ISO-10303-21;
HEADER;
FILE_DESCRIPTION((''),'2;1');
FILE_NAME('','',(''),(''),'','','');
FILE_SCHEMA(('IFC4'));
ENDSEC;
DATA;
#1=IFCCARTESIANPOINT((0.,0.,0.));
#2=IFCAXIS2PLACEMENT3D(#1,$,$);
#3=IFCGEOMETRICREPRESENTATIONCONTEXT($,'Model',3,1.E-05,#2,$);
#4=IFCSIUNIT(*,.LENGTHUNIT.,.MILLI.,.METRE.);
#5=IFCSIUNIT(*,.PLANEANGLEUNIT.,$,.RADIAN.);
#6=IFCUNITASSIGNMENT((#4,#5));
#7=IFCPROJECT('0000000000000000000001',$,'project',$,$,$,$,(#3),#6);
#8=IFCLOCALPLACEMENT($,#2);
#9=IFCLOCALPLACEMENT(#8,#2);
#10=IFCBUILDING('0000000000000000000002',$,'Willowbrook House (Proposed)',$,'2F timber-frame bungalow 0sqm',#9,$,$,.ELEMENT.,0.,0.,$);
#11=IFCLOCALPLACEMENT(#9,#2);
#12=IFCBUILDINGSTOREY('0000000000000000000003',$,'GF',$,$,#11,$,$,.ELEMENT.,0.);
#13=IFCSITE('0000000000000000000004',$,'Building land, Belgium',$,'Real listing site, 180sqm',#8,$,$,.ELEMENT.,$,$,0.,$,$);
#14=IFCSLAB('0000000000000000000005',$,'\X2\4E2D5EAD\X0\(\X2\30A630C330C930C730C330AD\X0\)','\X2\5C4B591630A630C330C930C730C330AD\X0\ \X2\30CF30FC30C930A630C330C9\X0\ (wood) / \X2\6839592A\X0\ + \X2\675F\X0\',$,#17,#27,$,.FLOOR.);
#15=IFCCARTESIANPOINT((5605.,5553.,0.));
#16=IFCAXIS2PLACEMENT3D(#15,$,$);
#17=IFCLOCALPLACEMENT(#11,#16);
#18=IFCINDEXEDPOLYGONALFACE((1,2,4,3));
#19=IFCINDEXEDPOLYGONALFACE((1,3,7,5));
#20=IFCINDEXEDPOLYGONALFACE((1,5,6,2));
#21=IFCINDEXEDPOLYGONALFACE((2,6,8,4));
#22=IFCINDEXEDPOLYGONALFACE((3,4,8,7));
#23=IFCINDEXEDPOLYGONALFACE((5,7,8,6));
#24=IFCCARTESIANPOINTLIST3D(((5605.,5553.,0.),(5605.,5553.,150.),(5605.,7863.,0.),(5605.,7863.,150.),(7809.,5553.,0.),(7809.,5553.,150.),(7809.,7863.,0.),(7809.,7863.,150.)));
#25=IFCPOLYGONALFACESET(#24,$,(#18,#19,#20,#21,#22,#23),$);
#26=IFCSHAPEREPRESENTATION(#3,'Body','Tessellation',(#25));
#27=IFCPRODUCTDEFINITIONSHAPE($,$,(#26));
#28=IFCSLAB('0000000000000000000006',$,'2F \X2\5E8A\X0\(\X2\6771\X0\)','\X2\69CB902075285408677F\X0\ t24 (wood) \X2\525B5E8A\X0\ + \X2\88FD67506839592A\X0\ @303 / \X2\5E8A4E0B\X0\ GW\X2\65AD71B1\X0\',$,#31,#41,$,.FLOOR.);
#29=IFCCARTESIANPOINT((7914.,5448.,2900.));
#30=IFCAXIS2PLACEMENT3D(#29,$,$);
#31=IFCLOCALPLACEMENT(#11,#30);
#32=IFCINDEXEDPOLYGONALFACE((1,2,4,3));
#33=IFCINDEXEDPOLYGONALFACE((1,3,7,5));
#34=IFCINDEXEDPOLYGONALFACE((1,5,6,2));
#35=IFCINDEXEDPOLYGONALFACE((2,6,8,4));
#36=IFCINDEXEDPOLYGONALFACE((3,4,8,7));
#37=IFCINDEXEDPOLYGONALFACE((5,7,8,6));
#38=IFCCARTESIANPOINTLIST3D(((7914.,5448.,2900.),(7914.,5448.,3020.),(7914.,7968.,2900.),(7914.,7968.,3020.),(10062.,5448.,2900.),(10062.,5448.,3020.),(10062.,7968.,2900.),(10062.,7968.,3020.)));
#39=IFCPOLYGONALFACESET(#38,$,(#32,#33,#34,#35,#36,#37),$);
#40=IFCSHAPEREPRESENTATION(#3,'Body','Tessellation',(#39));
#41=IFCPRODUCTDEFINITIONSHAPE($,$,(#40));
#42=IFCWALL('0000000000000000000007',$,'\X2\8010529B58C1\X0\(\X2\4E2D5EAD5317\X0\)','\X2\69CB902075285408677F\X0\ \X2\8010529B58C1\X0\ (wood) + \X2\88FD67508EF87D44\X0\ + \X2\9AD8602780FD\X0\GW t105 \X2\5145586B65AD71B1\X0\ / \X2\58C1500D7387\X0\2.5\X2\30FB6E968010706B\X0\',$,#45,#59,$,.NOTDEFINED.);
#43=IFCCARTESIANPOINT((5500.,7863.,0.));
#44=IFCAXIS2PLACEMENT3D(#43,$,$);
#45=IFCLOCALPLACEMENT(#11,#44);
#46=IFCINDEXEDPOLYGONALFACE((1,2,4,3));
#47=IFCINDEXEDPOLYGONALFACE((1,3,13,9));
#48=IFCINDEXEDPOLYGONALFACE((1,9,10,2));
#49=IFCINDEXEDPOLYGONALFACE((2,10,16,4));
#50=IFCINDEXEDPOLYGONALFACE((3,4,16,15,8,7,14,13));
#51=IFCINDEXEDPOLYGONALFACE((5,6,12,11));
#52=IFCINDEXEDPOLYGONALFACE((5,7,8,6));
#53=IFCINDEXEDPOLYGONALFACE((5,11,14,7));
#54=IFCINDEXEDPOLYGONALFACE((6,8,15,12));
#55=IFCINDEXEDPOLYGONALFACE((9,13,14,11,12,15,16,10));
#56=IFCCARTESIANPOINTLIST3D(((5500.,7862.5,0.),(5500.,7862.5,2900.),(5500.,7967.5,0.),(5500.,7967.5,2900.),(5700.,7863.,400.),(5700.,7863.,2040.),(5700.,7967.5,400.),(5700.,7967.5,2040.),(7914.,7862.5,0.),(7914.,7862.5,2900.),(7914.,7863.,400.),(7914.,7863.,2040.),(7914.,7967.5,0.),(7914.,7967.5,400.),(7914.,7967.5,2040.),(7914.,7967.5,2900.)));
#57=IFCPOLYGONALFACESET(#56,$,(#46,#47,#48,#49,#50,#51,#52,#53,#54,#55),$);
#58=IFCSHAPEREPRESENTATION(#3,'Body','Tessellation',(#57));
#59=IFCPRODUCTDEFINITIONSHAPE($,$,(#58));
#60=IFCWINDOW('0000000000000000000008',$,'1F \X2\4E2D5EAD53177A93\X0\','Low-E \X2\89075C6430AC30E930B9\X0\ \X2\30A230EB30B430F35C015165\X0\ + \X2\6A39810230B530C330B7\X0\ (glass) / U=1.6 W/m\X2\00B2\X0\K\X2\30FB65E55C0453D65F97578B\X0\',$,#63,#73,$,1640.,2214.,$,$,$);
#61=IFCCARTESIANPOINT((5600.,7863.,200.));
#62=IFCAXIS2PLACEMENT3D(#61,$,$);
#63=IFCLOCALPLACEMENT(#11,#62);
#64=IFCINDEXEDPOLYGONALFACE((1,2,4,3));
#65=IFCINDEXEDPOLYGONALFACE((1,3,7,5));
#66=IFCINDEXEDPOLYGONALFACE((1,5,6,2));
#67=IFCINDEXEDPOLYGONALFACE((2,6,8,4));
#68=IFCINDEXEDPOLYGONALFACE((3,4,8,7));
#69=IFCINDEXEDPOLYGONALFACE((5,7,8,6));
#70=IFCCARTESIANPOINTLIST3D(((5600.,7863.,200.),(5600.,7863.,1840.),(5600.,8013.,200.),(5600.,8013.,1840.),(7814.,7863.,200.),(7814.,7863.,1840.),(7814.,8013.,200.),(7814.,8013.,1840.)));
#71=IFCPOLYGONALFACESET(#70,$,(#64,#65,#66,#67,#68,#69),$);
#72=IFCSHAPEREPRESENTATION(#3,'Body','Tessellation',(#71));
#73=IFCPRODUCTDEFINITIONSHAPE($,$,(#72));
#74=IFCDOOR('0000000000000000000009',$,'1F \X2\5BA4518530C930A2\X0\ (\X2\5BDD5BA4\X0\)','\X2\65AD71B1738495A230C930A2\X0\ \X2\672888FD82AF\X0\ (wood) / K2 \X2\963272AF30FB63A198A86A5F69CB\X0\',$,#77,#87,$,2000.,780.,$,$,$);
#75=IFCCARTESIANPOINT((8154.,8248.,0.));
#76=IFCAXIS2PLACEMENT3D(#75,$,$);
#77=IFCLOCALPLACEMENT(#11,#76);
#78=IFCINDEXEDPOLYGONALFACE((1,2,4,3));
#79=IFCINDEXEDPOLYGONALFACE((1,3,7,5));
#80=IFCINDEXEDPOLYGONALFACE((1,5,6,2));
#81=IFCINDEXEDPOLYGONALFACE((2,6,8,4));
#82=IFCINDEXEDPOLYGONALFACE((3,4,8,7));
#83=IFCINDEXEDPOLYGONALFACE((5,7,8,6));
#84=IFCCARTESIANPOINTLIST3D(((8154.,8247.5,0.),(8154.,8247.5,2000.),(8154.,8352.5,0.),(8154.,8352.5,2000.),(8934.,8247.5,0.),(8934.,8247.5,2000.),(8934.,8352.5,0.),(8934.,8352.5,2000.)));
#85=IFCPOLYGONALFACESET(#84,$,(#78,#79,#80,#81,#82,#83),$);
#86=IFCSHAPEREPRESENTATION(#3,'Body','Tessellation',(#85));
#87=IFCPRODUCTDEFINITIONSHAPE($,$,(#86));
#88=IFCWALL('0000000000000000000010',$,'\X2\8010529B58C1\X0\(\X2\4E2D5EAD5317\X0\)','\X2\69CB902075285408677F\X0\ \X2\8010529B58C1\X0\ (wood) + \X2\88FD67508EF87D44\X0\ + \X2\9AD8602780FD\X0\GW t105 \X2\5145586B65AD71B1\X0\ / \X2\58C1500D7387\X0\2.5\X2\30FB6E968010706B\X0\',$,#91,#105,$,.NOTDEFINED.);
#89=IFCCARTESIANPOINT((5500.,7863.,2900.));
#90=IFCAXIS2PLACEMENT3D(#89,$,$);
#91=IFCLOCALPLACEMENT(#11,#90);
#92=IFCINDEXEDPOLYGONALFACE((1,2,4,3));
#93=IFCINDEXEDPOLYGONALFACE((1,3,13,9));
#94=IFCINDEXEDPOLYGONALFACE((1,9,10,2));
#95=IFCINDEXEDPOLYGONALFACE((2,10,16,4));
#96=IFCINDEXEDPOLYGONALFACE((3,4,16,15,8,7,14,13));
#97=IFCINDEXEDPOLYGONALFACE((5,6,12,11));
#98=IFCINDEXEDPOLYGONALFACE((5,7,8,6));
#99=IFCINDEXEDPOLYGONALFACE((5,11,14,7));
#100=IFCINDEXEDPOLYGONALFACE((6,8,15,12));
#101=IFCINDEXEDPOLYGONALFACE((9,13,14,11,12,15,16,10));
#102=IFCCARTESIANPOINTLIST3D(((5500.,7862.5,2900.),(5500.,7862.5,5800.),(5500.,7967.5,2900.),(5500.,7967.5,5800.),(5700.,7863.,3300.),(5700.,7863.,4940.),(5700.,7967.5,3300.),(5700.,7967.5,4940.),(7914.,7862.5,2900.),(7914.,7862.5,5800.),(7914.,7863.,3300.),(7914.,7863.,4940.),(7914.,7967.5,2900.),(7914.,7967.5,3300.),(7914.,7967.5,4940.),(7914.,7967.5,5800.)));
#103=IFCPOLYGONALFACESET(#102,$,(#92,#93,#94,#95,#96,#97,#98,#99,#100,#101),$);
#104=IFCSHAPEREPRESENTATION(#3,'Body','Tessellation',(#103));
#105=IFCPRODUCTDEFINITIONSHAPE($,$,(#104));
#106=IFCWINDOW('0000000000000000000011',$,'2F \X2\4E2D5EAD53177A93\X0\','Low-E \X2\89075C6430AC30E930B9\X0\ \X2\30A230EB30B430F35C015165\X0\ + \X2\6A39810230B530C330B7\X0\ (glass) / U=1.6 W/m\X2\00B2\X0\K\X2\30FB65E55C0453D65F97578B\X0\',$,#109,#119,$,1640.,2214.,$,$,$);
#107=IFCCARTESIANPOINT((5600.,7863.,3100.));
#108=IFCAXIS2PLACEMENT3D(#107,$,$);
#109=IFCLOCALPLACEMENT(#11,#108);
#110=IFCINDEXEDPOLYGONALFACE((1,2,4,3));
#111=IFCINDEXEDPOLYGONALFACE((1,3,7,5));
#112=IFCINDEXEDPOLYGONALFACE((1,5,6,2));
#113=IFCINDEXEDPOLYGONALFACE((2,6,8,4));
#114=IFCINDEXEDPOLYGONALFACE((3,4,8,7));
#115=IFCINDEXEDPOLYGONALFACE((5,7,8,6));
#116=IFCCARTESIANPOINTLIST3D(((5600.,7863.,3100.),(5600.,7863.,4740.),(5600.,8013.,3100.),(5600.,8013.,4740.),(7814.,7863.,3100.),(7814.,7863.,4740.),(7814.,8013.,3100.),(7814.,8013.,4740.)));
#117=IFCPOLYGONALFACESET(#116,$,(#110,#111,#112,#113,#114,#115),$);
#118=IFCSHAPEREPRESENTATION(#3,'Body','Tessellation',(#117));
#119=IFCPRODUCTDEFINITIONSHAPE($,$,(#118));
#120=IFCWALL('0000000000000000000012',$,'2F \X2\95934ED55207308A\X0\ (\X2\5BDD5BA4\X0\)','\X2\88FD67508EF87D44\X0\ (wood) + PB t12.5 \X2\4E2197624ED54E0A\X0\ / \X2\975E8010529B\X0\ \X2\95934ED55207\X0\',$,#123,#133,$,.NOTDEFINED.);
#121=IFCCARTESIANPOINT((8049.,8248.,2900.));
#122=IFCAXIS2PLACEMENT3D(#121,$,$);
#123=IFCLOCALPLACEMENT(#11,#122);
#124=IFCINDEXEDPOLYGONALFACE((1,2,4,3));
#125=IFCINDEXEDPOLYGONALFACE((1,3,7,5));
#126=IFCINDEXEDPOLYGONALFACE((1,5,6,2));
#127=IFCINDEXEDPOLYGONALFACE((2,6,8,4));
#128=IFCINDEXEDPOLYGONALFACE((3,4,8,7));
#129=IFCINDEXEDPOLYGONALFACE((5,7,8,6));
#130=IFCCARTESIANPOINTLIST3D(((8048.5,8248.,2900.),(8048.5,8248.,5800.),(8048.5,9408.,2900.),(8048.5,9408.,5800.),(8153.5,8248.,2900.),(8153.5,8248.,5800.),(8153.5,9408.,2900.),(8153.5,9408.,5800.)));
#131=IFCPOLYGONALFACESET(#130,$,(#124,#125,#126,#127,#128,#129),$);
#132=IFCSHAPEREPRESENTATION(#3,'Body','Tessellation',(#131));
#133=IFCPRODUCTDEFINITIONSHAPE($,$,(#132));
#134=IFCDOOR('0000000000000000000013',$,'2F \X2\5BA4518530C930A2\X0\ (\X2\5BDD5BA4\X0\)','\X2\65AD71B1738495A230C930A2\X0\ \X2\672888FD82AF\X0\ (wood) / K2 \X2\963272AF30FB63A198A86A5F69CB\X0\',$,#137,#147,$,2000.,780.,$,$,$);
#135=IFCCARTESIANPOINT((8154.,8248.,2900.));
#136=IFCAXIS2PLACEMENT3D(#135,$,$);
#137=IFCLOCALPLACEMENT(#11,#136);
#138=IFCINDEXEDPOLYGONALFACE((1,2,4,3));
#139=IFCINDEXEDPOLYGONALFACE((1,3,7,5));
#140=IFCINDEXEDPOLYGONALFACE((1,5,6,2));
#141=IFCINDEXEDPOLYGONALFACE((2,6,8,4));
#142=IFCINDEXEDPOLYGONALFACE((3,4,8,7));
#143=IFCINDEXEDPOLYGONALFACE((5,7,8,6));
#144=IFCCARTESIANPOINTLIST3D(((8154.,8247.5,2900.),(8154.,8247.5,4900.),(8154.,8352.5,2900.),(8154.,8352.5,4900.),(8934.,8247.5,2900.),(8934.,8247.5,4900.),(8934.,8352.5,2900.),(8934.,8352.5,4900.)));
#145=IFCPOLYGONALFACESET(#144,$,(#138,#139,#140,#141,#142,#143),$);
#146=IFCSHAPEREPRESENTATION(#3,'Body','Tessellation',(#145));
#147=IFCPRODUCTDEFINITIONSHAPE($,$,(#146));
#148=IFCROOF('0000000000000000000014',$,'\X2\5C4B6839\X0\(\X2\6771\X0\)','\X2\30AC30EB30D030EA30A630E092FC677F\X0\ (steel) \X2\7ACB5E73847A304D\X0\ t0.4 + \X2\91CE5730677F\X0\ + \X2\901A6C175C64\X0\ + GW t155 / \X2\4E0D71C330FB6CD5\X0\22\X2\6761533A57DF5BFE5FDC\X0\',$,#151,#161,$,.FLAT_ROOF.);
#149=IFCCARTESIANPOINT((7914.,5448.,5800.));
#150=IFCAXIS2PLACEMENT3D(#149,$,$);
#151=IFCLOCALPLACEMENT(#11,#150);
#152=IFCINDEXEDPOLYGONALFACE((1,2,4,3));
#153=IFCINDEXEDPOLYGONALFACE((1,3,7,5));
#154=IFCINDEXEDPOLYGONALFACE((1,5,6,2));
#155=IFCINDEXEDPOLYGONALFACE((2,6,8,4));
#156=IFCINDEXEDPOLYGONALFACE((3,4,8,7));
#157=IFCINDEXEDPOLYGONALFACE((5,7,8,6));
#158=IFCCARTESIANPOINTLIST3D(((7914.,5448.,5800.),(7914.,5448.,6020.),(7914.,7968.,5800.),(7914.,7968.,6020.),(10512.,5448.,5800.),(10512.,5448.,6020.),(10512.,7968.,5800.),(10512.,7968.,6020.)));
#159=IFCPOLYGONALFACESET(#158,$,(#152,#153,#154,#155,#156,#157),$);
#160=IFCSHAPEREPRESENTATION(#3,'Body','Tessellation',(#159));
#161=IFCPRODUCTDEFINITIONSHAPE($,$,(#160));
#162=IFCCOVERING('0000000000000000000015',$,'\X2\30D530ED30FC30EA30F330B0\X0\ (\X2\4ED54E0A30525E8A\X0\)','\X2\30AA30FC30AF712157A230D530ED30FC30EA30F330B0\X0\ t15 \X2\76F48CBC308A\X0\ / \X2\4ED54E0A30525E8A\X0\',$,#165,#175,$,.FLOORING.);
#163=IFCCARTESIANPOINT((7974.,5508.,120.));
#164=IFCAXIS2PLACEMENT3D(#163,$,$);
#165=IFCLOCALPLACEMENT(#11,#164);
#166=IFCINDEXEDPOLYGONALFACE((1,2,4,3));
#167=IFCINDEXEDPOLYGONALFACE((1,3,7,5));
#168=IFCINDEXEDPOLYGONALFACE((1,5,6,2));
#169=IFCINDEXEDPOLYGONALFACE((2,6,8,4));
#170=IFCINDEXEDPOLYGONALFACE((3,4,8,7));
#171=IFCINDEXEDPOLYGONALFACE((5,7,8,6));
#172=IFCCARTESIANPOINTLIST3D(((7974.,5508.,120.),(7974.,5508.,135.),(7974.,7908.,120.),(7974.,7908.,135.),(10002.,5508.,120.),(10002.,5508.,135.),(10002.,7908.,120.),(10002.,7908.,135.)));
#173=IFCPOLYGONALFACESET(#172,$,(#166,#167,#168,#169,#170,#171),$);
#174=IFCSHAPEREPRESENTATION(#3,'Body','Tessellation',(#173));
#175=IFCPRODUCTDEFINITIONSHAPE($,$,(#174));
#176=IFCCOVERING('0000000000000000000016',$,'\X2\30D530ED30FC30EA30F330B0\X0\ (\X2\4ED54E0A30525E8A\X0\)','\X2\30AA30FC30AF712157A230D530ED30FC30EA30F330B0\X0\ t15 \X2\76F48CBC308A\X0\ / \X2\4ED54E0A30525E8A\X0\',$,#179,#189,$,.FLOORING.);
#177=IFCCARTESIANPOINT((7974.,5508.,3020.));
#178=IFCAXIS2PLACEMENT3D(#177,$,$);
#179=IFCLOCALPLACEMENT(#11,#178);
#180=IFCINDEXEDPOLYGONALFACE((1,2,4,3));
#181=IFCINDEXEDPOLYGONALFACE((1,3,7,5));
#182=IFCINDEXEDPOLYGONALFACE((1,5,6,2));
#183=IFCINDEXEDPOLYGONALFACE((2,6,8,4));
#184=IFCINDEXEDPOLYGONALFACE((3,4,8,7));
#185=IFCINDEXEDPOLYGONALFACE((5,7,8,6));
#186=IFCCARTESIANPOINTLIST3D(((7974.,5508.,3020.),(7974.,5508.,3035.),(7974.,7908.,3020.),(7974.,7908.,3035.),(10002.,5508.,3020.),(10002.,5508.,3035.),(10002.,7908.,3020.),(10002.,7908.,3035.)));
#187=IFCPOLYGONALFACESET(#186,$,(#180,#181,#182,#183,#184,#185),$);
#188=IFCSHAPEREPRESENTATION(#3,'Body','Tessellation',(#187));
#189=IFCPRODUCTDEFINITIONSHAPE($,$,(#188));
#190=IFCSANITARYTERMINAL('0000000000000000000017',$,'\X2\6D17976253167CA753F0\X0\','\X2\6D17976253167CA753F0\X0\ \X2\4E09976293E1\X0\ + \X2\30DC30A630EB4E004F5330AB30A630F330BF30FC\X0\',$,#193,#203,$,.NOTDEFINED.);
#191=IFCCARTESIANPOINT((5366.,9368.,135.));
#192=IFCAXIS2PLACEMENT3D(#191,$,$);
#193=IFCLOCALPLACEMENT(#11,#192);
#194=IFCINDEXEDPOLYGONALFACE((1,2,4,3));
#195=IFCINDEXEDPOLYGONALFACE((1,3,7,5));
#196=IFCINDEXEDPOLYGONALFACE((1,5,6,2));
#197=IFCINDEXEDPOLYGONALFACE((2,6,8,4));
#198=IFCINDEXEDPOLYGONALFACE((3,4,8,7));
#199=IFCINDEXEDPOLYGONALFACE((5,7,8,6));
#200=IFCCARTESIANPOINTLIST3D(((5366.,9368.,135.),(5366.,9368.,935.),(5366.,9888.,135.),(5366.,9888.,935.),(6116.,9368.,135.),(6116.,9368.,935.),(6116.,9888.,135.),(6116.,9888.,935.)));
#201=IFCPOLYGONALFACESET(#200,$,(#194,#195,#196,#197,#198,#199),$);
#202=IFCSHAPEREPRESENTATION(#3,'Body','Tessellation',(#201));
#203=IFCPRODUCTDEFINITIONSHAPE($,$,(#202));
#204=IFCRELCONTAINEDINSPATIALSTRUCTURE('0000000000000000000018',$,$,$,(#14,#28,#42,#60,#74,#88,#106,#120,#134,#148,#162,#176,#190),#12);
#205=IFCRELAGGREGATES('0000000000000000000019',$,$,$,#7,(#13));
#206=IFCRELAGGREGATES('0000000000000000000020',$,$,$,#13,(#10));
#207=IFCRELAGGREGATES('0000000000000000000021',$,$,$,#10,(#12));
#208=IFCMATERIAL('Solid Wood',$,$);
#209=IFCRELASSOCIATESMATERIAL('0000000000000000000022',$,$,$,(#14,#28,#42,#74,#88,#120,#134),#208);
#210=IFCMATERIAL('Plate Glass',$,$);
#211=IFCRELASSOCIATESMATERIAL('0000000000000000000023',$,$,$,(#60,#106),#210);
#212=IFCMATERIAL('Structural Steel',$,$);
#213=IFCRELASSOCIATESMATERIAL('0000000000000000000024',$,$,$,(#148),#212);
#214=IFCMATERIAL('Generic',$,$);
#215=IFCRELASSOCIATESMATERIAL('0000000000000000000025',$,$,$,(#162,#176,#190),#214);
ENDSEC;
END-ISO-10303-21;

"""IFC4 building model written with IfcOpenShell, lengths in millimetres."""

from ifc_helpers import new_model, si_unit, frame, frame_2d, origin, place, context, project, spatial, rectangle, extrude, material, element, fill, save


model = new_model("IFC4")

# Units and contexts
model_context = context("Model", 3, precision=1e-05, world=origin())
ifc_project = project(units=[si_unit("LENGTHUNIT", "METRE", prefix="MILLI"), si_unit("PLANEANGLEUNIT", "RADIAN")], contexts=[model_context])

# Site, building, storey
site_placement = place(None, origin())
site = spatial("IfcSite", under=ifc_project, at=site_placement, Name="Building land, Belgium", ObjectType="Real listing site, 180sqm", CompositionType="ELEMENT", RefElevation=0.0)
building_placement = place(site_placement, origin())
building = spatial("IfcBuilding", under=site, at=building_placement, Name="Willowbrook House (Proposed)", ObjectType="2F timber-frame bungalow 0sqm", CompositionType="ELEMENT", ElevationOfRefHeight=0.0, ElevationOfTerrain=0.0)
storey_placement = place(building_placement, origin())
storey = spatial("IfcBuildingStorey", under=building, at=storey_placement, Name="GF", CompositionType="ELEMENT", Elevation=0.0)

# Slabs
ifc_material_1 = material(Name="Solid Wood")
slab_1_placement = place(storey_placement, frame((5605.0, 5553.0, 0.0)))
element("IfcSlab", 1, at=slab_1_placement, inside=storey, material=ifc_material_1, Name="中庭(ウッドデッキ)", Description="屋外ウッドデッキ ハードウッド (wood) / 根太 + 束", PredefinedType="FLOOR", context=model_context, shape_type="SweptSolid", body=[
    extrude(rectangle(XDim=2204.0, YDim=2310.0, at=frame_2d((1102.0, 1155.0))), frame((5605.0, 5553.0, 0.0)), (0.0, 0.0, 1.0), 150.0),
])
slab_2_placement = place(storey_placement, frame((7914.0, 5448.0, 2900.0)))
element("IfcSlab", 2, at=slab_2_placement, inside=storey, material=ifc_material_1, Name="2F 床(東)", Description="構造用合板 t24 (wood) 剛床 + 製材根太 @303 / 床下 GW断熱", PredefinedType="FLOOR", context=model_context, shape_type="SweptSolid", body=[
    extrude(rectangle(XDim=2148.0, YDim=2520.0, at=frame_2d((1074.0, 1260.0))), frame((7914.0, 5448.0, 2900.0)), (0.0, 0.0, 1.0), 120.0),
])

# Wall, opening, window
wall_1_placement = place(storey_placement, frame((5500.0, 7863.0, 0.0)))
wall_1 = element("IfcWall", 3, at=wall_1_placement, inside=storey, material=ifc_material_1, Name="耐力壁(中庭北)", Description="構造用合板 耐力壁 (wood) + 製材軸組 + 高性能GW t105 充填断熱 / 壁倍率2.5・準耐火", PredefinedType="NOTDEFINED", context=model_context, shape_type="SweptSolid", body=[
    extrude(rectangle(XDim=2414.0, YDim=105.0, at=frame_2d((1207.0, 52.0))), frame((5500.0, 7863.0, 0.0)), (0.0, 0.0, 1.0), 2900.0),
])
opening_1_placement = place(storey_placement, frame((5600.0, 7863.0, 200.0)))
opening_1 = element("IfcOpeningElement", 4, at=opening_1_placement, cuts=wall_1, PredefinedType="NOTDEFINED", context=model_context, shape_type="SweptSolid", body=[
    extrude(rectangle(XDim=2214.0, YDim=150.0, at=frame_2d((1107.0, 75.0))), frame((5600.0, 7863.0, 200.0)), (0.0, 0.0, 1.0), 1640.0),
])
ifc_material_2 = material(Name="Plate Glass")
window_1_placement = place(storey_placement, frame((5600.0, 7863.0, 200.0)))
window_1 = element("IfcWindow", 5, at=window_1_placement, inside=storey, material=ifc_material_2, Name="1F 中庭北窓", Description="Low-E 複層ガラス アルゴン封入 + 樹脂サッシ (glass) / U=1.6 W/m²K・日射取得型", OverallHeight=1640.0, OverallWidth=2214.0, context=model_context, shape_type="SweptSolid", body=[
    extrude(rectangle(XDim=2214.0, YDim=150.0, at=frame_2d((1107.0, 75.0))), frame((5600.0, 7863.0, 200.0)), (0.0, 0.0, 1.0), 1640.0),
])
fill(opening_1, window_1)

# Door
door_1_placement = place(storey_placement, frame((8154.0, 8248.0, 0.0)))
element("IfcDoor", 6, at=door_1_placement, inside=storey, material=ifc_material_1, Name="1F 室内ドア (寝室)", Description="断熱玄関ドア 木製芯 (wood) / K2 防犯・採風機構", OverallHeight=2000.0, OverallWidth=780.0, context=model_context, shape_type="SweptSolid", body=[
    extrude(rectangle(XDim=780.0, YDim=105.0, at=frame_2d((390.0, 52.0))), frame((8154.0, 8248.0, 0.0)), (0.0, 0.0, 1.0), 2000.0),
])

# Wall, opening, window
wall_2_placement = place(storey_placement, frame((5500.0, 7863.0, 2900.0)))
wall_2 = element("IfcWall", 7, at=wall_2_placement, inside=storey, material=ifc_material_1, Name="耐力壁(中庭北)", Description="構造用合板 耐力壁 (wood) + 製材軸組 + 高性能GW t105 充填断熱 / 壁倍率2.5・準耐火", PredefinedType="NOTDEFINED", context=model_context, shape_type="SweptSolid", body=[
    extrude(rectangle(XDim=2414.0, YDim=105.0, at=frame_2d((1207.0, 52.0))), frame((5500.0, 7863.0, 2900.0)), (0.0, 0.0, 1.0), 2900.0),
])
opening_2_placement = place(storey_placement, frame((5600.0, 7863.0, 3100.0)))
opening_2 = element("IfcOpeningElement", 8, at=opening_2_placement, cuts=wall_2, PredefinedType="NOTDEFINED", context=model_context, shape_type="SweptSolid", body=[
    extrude(rectangle(XDim=2214.0, YDim=150.0, at=frame_2d((1107.0, 75.0))), frame((5600.0, 7863.0, 3100.0)), (0.0, 0.0, 1.0), 1640.0),
])
window_2_placement = place(storey_placement, frame((5600.0, 7863.0, 3100.0)))
window_2 = element("IfcWindow", 9, at=window_2_placement, inside=storey, material=ifc_material_2, Name="2F 中庭北窓", Description="Low-E 複層ガラス アルゴン封入 + 樹脂サッシ (glass) / U=1.6 W/m²K・日射取得型", OverallHeight=1640.0, OverallWidth=2214.0, context=model_context, shape_type="SweptSolid", body=[
    extrude(rectangle(XDim=2214.0, YDim=150.0, at=frame_2d((1107.0, 75.0))), frame((5600.0, 7863.0, 3100.0)), (0.0, 0.0, 1.0), 1640.0),
])
fill(opening_2, window_2)

# Wall
wall_3_placement = place(storey_placement, frame((8049.0, 8248.0, 2900.0)))
element("IfcWall", 10, at=wall_3_placement, inside=storey, material=ifc_material_1, Name="2F 間仕切り (寝室)", Description="製材軸組 (wood) + PB t12.5 両面仕上 / 非耐力 間仕切", PredefinedType="NOTDEFINED", context=model_context, shape_type="SweptSolid", body=[
    extrude(rectangle(XDim=105.0, YDim=1160.0, at=frame_2d((52.0, 580.0))), frame((8049.0, 8248.0, 2900.0)), (0.0, 0.0, 1.0), 2900.0),
])

# Door
door_2_placement = place(storey_placement, frame((8154.0, 8248.0, 2900.0)))
element("IfcDoor", 11, at=door_2_placement, inside=storey, material=ifc_material_1, Name="2F 室内ドア (寝室)", Description="断熱玄関ドア 木製芯 (wood) / K2 防犯・採風機構", OverallHeight=2000.0, OverallWidth=780.0, context=model_context, shape_type="SweptSolid", body=[
    extrude(rectangle(XDim=780.0, YDim=105.0, at=frame_2d((390.0, 52.0))), frame((8154.0, 8248.0, 2900.0)), (0.0, 0.0, 1.0), 2000.0),
])

# Roof
ifc_material_3 = material(Name="Structural Steel")
for number, where, name in (
    (12, (7914.0, 5448.0, 5800.0), "屋根(東)"),
):
    element("IfcRoof", number, at=place(storey_placement, frame(where)), inside=storey, material=ifc_material_3, Name=name, Description="ガルバリウム鋼板 (steel) 立平葺き t0.4 + 野地板 + 通気層 + GW t155 / 不燃・法22条区域対応", PredefinedType="FLAT_ROOF", context=model_context, shape_type="SweptSolid", body=[
        extrude(rectangle(XDim=2598.0, YDim=2520.0, at=frame_2d((1299.0, 1260.0))), frame((7914.0, 5448.0, 5800.0)), (0.0, 0.0, 1.0), 220.0),
    ])

# Coverings
ifc_material_4 = material(Name="Generic")
covering_1_placement = place(storey_placement, frame((7974.0, 5508.0, 120.0)))
element("IfcCovering", 13, at=covering_1_placement, inside=storey, material=ifc_material_4, Name="フローリング (仕上げ床)", Description="オーク無垢フローリング t15 直貼り / 仕上げ床", PredefinedType="FLOORING", context=model_context, shape_type="SweptSolid", body=[
    extrude(rectangle(XDim=2028.0, YDim=2400.0, at=frame_2d((1014.0, 1200.0))), frame((7974.0, 5508.0, 120.0)), (0.0, 0.0, 1.0), 15.0),
])
covering_2_placement = place(storey_placement, frame((7974.0, 5508.0, 3020.0)))
element("IfcCovering", 14, at=covering_2_placement, inside=storey, material=ifc_material_4, Name="フローリング (仕上げ床)", Description="オーク無垢フローリング t15 直貼り / 仕上げ床", PredefinedType="FLOORING", context=model_context, shape_type="SweptSolid", body=[
    extrude(rectangle(XDim=2028.0, YDim=2400.0, at=frame_2d((1014.0, 1200.0))), frame((7974.0, 5508.0, 3020.0)), (0.0, 0.0, 1.0), 15.0),
])

# Sanitary terminal
sanitary_terminal_1_placement = place(storey_placement, frame((5366.0, 9368.0, 135.0)))
element("IfcSanitaryTerminal", 15, at=sanitary_terminal_1_placement, inside=storey, material=ifc_material_4, Name="洗面化粧台", Description="洗面化粧台 三面鏡 + ボウル一体カウンター", PredefinedType="NOTDEFINED", context=model_context, shape_type="SweptSolid", body=[
    extrude(rectangle(XDim=750.0, YDim=520.0, at=frame_2d((375.0, 260.0))), frame((5366.0, 9368.0, 135.0)), (0.0, 0.0, 1.0), 800.0),
])

save(model, "model.ifc")
